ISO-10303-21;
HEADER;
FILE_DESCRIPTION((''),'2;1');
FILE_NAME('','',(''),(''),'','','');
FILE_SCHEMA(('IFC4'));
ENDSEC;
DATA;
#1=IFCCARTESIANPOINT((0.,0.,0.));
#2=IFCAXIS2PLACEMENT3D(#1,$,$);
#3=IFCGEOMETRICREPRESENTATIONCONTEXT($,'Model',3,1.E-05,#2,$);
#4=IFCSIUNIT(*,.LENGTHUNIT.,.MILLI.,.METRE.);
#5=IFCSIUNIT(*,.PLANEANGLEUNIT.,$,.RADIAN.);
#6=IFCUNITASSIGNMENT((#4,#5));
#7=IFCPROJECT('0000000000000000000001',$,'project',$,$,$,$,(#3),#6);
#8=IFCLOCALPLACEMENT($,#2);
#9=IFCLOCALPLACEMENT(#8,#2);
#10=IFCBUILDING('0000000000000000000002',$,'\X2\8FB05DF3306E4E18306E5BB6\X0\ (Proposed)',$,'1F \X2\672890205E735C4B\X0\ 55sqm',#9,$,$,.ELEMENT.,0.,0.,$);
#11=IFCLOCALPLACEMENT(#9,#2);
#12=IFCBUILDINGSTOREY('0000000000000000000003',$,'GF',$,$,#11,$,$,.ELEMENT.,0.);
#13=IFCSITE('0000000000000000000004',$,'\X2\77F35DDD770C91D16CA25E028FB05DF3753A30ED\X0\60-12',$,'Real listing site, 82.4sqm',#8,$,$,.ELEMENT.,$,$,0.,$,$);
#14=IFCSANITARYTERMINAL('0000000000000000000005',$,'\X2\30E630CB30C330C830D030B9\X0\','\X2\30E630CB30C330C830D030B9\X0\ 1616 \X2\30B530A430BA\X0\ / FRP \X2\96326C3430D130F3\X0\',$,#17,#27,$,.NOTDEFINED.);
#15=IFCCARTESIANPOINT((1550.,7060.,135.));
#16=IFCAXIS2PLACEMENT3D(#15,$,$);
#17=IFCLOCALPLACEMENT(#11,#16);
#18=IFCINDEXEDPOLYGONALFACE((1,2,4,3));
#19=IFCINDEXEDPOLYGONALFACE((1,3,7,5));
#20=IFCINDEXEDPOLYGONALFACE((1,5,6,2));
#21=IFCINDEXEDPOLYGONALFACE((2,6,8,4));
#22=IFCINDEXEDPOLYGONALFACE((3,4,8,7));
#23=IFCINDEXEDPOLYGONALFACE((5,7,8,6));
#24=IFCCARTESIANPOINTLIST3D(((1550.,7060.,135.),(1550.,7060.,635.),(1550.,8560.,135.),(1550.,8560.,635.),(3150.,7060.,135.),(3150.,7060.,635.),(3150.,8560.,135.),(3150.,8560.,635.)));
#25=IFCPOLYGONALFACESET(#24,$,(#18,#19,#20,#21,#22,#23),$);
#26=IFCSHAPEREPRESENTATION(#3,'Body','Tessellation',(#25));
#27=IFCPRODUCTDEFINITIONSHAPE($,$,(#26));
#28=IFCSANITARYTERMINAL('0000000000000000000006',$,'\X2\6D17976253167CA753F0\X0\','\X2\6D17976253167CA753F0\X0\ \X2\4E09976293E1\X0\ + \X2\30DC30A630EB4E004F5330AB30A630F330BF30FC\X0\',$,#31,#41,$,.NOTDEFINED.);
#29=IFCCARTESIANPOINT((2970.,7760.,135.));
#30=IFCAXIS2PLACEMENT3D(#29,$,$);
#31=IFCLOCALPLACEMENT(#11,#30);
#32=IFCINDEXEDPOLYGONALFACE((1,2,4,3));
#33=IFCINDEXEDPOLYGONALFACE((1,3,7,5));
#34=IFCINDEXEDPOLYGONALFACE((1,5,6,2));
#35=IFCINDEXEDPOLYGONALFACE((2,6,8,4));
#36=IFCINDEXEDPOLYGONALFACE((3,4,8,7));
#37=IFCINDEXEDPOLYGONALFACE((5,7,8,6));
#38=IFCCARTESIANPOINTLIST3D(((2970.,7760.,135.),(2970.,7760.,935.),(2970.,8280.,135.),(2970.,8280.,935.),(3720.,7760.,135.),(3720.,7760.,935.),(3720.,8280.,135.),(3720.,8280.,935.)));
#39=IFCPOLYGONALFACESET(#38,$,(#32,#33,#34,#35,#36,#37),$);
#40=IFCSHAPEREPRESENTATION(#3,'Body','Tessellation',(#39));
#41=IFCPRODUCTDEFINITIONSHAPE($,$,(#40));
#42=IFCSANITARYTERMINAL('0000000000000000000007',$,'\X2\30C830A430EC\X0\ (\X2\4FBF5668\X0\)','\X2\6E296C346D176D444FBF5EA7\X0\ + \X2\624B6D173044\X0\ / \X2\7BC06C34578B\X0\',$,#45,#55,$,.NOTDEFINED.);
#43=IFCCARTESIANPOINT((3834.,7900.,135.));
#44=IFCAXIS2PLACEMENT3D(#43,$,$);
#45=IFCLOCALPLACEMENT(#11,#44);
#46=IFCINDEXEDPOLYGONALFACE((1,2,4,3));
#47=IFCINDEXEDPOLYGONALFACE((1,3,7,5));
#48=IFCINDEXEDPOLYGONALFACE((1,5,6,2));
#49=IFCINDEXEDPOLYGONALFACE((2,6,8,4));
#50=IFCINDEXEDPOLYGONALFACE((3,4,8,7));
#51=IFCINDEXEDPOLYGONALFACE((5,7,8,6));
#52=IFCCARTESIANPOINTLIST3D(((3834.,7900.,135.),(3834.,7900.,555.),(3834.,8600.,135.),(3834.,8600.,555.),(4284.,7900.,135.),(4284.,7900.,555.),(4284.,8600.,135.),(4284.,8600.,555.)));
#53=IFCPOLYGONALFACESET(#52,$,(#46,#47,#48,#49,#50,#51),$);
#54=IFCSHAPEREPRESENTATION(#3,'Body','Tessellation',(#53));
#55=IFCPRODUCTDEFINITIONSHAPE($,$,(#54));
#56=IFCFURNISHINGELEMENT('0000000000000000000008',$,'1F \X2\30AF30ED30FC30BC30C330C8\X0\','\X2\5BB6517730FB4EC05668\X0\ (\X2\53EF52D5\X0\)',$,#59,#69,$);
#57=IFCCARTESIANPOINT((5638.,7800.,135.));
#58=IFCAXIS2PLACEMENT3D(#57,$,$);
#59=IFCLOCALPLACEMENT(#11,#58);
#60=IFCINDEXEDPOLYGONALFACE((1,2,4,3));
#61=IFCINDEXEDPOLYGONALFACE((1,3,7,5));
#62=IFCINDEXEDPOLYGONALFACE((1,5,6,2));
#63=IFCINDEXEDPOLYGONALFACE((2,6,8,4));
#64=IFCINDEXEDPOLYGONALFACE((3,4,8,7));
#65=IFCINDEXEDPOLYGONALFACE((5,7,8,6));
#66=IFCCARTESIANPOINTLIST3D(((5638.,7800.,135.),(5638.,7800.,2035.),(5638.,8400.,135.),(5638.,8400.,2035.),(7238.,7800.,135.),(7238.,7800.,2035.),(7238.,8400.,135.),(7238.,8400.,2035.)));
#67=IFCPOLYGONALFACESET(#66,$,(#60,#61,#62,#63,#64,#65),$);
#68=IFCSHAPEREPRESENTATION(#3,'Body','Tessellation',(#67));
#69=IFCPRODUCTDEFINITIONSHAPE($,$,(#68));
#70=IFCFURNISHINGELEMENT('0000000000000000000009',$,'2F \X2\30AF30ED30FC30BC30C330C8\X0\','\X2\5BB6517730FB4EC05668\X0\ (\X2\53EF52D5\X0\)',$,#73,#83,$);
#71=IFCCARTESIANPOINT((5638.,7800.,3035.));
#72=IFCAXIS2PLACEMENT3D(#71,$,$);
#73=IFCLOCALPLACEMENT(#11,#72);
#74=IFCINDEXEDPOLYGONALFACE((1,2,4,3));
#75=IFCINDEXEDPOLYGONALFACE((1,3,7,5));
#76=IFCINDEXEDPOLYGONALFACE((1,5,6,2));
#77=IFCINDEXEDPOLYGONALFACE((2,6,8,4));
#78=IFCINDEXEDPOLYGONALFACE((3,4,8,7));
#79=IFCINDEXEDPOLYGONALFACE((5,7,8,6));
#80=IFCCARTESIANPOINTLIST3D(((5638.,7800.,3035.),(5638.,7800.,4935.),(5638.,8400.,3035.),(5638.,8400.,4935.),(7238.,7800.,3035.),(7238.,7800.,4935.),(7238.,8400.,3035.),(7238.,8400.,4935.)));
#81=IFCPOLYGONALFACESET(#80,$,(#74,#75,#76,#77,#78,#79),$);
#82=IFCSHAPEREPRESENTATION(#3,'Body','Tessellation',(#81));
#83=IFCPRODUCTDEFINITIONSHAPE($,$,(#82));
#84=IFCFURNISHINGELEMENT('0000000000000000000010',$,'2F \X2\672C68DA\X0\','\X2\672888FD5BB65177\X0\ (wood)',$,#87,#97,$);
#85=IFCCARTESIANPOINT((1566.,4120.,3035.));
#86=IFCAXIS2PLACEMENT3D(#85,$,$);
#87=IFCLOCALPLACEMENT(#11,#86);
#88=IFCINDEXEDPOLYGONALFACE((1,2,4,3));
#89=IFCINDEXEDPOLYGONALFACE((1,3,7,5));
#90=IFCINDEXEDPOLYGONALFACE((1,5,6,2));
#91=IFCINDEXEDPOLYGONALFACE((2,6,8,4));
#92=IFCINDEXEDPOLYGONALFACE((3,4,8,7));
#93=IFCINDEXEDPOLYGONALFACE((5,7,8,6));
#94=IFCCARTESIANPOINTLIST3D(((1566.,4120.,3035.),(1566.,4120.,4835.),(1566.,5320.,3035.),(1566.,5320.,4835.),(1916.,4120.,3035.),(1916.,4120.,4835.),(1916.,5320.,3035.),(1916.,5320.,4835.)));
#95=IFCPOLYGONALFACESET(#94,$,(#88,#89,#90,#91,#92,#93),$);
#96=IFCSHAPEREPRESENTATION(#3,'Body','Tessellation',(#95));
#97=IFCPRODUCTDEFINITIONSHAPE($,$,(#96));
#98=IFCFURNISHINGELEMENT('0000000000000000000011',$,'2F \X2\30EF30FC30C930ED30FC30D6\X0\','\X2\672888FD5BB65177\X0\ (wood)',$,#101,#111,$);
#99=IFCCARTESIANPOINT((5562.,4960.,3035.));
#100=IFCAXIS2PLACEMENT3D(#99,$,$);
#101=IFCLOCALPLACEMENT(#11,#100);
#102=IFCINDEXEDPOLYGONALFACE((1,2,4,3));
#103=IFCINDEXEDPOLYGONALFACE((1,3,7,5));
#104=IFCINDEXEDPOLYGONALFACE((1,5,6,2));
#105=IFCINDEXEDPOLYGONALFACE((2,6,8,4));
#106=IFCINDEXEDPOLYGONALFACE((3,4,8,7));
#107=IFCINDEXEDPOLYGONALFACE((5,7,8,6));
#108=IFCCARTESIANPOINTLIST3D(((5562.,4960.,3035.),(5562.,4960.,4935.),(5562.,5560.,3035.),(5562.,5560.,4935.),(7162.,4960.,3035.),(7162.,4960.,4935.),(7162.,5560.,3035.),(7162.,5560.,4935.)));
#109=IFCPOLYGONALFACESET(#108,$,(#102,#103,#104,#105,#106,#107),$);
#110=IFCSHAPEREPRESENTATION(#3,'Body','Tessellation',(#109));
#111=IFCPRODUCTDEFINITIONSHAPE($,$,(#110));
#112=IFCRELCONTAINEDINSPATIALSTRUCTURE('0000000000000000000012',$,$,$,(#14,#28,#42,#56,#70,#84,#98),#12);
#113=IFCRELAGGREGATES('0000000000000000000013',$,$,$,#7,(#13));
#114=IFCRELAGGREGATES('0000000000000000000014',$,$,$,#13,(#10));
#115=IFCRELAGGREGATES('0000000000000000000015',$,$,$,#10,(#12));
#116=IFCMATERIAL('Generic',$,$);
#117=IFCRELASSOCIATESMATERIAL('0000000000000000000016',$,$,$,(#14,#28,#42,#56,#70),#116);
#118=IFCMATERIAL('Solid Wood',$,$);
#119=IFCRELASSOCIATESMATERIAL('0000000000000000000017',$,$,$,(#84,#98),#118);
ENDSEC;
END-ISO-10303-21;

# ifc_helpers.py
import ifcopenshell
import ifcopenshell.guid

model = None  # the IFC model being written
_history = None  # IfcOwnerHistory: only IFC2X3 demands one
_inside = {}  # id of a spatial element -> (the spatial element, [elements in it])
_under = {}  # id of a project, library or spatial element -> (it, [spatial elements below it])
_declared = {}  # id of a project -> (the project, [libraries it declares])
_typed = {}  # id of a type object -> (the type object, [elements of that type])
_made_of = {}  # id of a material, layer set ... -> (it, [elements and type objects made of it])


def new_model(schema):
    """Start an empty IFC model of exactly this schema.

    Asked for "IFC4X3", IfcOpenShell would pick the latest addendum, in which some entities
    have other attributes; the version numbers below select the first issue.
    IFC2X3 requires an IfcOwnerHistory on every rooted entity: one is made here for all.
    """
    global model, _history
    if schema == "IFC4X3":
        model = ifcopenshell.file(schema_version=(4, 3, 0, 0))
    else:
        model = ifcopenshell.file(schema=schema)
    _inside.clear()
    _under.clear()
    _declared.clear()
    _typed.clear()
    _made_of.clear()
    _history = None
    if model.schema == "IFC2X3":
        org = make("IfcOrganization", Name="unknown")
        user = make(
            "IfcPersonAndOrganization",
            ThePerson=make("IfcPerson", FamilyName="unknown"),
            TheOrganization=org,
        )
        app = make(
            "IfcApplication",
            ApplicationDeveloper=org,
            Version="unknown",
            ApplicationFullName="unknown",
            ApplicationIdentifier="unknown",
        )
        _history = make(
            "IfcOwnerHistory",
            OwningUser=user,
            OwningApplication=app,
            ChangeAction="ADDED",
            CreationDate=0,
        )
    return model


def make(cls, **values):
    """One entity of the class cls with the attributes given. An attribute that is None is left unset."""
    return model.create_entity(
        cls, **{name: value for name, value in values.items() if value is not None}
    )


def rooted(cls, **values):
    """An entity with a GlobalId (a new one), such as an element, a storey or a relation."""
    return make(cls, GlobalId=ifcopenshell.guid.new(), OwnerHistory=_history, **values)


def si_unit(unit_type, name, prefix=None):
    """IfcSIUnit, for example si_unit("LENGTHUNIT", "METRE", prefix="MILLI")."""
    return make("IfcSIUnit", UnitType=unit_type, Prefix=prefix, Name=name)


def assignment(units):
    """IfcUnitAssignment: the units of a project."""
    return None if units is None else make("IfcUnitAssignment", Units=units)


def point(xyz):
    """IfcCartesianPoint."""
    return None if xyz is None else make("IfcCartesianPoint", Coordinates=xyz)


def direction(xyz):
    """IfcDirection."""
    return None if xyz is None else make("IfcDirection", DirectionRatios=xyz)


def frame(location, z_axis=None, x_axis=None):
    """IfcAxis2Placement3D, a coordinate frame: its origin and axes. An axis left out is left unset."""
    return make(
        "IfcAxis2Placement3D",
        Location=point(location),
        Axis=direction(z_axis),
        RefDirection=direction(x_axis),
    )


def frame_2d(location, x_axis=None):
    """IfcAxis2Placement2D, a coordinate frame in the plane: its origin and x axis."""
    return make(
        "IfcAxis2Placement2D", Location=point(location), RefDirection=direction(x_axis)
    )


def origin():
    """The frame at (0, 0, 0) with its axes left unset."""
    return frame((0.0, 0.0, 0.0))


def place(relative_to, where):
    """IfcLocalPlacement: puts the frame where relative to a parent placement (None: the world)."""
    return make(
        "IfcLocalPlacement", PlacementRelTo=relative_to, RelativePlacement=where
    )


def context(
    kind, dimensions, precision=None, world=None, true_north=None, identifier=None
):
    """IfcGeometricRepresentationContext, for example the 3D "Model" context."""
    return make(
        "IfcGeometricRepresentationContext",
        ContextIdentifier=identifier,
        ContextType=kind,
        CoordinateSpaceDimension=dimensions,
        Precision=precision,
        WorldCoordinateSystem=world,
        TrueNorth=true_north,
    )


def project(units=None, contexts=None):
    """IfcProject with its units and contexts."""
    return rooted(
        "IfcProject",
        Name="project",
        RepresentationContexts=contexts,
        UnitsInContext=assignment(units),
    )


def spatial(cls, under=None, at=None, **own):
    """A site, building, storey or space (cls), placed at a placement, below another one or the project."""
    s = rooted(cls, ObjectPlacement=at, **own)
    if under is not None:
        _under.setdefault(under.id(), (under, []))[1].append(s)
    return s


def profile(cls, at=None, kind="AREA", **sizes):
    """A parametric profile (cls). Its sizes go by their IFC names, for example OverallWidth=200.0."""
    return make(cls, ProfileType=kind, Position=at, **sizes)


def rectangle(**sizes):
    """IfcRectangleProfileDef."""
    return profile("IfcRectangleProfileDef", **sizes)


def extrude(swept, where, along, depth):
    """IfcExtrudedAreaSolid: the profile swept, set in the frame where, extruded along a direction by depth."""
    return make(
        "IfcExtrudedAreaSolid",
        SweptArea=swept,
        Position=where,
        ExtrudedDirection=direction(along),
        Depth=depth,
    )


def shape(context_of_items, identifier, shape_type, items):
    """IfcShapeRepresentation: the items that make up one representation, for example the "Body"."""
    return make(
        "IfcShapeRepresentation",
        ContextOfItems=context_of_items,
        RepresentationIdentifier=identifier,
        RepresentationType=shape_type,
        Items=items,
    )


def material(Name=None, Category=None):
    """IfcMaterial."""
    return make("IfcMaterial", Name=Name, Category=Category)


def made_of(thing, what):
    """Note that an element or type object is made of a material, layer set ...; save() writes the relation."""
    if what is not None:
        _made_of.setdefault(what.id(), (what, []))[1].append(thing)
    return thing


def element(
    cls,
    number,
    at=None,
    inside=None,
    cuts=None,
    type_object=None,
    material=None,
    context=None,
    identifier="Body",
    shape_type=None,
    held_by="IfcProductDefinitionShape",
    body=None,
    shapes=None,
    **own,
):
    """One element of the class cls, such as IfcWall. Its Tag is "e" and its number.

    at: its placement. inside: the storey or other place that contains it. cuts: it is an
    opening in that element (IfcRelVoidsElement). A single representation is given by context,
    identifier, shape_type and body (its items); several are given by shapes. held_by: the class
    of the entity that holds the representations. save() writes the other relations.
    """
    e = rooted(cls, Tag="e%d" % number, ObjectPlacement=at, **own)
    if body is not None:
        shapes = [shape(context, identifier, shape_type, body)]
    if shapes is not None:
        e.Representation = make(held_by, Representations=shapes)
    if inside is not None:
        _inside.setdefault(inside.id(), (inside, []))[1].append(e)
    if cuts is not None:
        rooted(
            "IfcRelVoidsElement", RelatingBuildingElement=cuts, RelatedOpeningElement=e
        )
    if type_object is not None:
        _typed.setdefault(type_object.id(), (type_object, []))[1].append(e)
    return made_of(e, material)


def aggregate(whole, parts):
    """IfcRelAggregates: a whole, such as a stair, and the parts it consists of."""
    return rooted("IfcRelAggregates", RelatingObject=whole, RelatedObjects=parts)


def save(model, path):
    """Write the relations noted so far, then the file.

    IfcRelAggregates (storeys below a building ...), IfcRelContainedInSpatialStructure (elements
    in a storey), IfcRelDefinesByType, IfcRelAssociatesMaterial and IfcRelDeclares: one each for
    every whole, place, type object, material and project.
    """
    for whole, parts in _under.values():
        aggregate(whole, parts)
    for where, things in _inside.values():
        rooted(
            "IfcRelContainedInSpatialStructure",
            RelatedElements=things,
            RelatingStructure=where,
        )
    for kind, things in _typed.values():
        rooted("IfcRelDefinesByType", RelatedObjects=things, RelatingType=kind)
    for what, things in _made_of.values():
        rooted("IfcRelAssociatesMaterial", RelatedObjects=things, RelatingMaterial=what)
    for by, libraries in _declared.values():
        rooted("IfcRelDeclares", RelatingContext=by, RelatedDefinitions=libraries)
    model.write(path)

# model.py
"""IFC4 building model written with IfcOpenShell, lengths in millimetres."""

from ifc_helpers import new_model, si_unit, frame, frame_2d, origin, place, context, project, spatial, rectangle, extrude, material, element, save


model = new_model("IFC4")

# Units and contexts
model_context = context("Model", 3, precision=1e-05, world=origin())
ifc_project = project(units=[si_unit("LENGTHUNIT", "METRE", prefix="MILLI"), si_unit("PLANEANGLEUNIT", "RADIAN")], contexts=[model_context])

# Site, building, storey
site_placement = place(None, origin())
site = spatial("IfcSite", under=ifc_project, at=site_placement, Name="石川県金沢市辰巳町ロ60-12", ObjectType="Real listing site, 82.4sqm", CompositionType="ELEMENT", RefElevation=0.0)
building_placement = place(site_placement, origin())
building = spatial("IfcBuilding", under=site, at=building_placement, Name="辰巳の丘の家 (Proposed)", ObjectType="1F 木造平屋 55sqm", CompositionType="ELEMENT", ElevationOfRefHeight=0.0, ElevationOfTerrain=0.0)
storey_placement = place(building_placement, origin())
storey = spatial("IfcBuildingStorey", under=building, at=storey_placement, Name="GF", CompositionType="ELEMENT", Elevation=0.0)

# Shared definitions
ifc_material_1 = material(Name="Solid Wood")

# Shared definitions
ifc_material_2 = material(Name="Generic")

# Sanitary terminals
sanitary_terminal_1_placement = place(storey_placement, frame((1550.0, 7060.0, 135.0)))
element("IfcSanitaryTerminal", 1, at=sanitary_terminal_1_placement, inside=storey, material=ifc_material_2, Name="ユニットバス", Description="ユニットバス 1616 サイズ / FRP 防水パン", PredefinedType="NOTDEFINED", context=model_context, shape_type="SweptSolid", body=[
    extrude(rectangle(XDim=1600.0, YDim=1500.0, at=frame_2d((800.0, 750.0))), frame((1550.0, 7060.0, 135.0)), (0.0, 0.0, 1.0), 500.0),
])
sanitary_terminal_2_placement = place(storey_placement, frame((2970.0, 7760.0, 135.0)))
element("IfcSanitaryTerminal", 2, at=sanitary_terminal_2_placement, inside=storey, material=ifc_material_2, Name="洗面化粧台", Description="洗面化粧台 三面鏡 + ボウル一体カウンター", PredefinedType="NOTDEFINED", context=model_context, shape_type="SweptSolid", body=[
    extrude(rectangle(XDim=750.0, YDim=520.0, at=frame_2d((375.0, 260.0))), frame((2970.0, 7760.0, 135.0)), (0.0, 0.0, 1.0), 800.0),
])
sanitary_terminal_3_placement = place(storey_placement, frame((3834.0, 7900.0, 135.0)))
element("IfcSanitaryTerminal", 3, at=sanitary_terminal_3_placement, inside=storey, material=ifc_material_2, Name="トイレ (便器)", Description="温水洗浄便座 + 手洗い / 節水型", PredefinedType="NOTDEFINED", context=model_context, shape_type="SweptSolid", body=[
    extrude(rectangle(XDim=450.0, YDim=700.0, at=frame_2d((225.0, 350.0))), frame((3834.0, 7900.0, 135.0)), (0.0, 0.0, 1.0), 420.0),
])

# Furnishing elements
furnishing_1_placement = place(storey_placement, frame((5638.0, 7800.0, 135.0)))
element("IfcFurnishingElement", 4, at=furnishing_1_placement, inside=storey, material=ifc_material_2, Name="1F クローゼット", Description="家具・什器 (可動)", context=model_context, shape_type="SweptSolid", body=[
    extrude(rectangle(XDim=1600.0, YDim=600.0, at=frame_2d((800.0, 300.0))), frame((5638.0, 7800.0, 135.0)), (0.0, 0.0, 1.0), 1900.0),
])
furnishing_2_placement = place(storey_placement, frame((5638.0, 7800.0, 3035.0)))
element("IfcFurnishingElement", 5, at=furnishing_2_placement, inside=storey, material=ifc_material_2, Name="2F クローゼット", Description="家具・什器 (可動)", context=model_context, shape_type="SweptSolid", body=[
    extrude(rectangle(XDim=1600.0, YDim=600.0, at=frame_2d((800.0, 300.0))), frame((5638.0, 7800.0, 3035.0)), (0.0, 0.0, 1.0), 1900.0),
])
furnishing_3_placement = place(storey_placement, frame((1566.0, 4120.0, 3035.0)))
element("IfcFurnishingElement", 6, at=furnishing_3_placement, inside=storey, material=ifc_material_1, Name="2F 本棚", Description="木製家具 (wood)", context=model_context, shape_type="SweptSolid", body=[
    extrude(rectangle(XDim=350.0, YDim=1200.0, at=frame_2d((175.0, 600.0))), frame((1566.0, 4120.0, 3035.0)), (0.0, 0.0, 1.0), 1800.0),
])
furnishing_4_placement = place(storey_placement, frame((5562.0, 4960.0, 3035.0)))
element("IfcFurnishingElement", 7, at=furnishing_4_placement, inside=storey, material=ifc_material_1, Name="2F ワードローブ", Description="木製家具 (wood)", context=model_context, shape_type="SweptSolid", body=[
    extrude(rectangle(XDim=1600.0, YDim=600.0, at=frame_2d((800.0, 300.0))), frame((5562.0, 4960.0, 3035.0)), (0.0, 0.0, 1.0), 1900.0),
])

save(model, "model.ifc")
